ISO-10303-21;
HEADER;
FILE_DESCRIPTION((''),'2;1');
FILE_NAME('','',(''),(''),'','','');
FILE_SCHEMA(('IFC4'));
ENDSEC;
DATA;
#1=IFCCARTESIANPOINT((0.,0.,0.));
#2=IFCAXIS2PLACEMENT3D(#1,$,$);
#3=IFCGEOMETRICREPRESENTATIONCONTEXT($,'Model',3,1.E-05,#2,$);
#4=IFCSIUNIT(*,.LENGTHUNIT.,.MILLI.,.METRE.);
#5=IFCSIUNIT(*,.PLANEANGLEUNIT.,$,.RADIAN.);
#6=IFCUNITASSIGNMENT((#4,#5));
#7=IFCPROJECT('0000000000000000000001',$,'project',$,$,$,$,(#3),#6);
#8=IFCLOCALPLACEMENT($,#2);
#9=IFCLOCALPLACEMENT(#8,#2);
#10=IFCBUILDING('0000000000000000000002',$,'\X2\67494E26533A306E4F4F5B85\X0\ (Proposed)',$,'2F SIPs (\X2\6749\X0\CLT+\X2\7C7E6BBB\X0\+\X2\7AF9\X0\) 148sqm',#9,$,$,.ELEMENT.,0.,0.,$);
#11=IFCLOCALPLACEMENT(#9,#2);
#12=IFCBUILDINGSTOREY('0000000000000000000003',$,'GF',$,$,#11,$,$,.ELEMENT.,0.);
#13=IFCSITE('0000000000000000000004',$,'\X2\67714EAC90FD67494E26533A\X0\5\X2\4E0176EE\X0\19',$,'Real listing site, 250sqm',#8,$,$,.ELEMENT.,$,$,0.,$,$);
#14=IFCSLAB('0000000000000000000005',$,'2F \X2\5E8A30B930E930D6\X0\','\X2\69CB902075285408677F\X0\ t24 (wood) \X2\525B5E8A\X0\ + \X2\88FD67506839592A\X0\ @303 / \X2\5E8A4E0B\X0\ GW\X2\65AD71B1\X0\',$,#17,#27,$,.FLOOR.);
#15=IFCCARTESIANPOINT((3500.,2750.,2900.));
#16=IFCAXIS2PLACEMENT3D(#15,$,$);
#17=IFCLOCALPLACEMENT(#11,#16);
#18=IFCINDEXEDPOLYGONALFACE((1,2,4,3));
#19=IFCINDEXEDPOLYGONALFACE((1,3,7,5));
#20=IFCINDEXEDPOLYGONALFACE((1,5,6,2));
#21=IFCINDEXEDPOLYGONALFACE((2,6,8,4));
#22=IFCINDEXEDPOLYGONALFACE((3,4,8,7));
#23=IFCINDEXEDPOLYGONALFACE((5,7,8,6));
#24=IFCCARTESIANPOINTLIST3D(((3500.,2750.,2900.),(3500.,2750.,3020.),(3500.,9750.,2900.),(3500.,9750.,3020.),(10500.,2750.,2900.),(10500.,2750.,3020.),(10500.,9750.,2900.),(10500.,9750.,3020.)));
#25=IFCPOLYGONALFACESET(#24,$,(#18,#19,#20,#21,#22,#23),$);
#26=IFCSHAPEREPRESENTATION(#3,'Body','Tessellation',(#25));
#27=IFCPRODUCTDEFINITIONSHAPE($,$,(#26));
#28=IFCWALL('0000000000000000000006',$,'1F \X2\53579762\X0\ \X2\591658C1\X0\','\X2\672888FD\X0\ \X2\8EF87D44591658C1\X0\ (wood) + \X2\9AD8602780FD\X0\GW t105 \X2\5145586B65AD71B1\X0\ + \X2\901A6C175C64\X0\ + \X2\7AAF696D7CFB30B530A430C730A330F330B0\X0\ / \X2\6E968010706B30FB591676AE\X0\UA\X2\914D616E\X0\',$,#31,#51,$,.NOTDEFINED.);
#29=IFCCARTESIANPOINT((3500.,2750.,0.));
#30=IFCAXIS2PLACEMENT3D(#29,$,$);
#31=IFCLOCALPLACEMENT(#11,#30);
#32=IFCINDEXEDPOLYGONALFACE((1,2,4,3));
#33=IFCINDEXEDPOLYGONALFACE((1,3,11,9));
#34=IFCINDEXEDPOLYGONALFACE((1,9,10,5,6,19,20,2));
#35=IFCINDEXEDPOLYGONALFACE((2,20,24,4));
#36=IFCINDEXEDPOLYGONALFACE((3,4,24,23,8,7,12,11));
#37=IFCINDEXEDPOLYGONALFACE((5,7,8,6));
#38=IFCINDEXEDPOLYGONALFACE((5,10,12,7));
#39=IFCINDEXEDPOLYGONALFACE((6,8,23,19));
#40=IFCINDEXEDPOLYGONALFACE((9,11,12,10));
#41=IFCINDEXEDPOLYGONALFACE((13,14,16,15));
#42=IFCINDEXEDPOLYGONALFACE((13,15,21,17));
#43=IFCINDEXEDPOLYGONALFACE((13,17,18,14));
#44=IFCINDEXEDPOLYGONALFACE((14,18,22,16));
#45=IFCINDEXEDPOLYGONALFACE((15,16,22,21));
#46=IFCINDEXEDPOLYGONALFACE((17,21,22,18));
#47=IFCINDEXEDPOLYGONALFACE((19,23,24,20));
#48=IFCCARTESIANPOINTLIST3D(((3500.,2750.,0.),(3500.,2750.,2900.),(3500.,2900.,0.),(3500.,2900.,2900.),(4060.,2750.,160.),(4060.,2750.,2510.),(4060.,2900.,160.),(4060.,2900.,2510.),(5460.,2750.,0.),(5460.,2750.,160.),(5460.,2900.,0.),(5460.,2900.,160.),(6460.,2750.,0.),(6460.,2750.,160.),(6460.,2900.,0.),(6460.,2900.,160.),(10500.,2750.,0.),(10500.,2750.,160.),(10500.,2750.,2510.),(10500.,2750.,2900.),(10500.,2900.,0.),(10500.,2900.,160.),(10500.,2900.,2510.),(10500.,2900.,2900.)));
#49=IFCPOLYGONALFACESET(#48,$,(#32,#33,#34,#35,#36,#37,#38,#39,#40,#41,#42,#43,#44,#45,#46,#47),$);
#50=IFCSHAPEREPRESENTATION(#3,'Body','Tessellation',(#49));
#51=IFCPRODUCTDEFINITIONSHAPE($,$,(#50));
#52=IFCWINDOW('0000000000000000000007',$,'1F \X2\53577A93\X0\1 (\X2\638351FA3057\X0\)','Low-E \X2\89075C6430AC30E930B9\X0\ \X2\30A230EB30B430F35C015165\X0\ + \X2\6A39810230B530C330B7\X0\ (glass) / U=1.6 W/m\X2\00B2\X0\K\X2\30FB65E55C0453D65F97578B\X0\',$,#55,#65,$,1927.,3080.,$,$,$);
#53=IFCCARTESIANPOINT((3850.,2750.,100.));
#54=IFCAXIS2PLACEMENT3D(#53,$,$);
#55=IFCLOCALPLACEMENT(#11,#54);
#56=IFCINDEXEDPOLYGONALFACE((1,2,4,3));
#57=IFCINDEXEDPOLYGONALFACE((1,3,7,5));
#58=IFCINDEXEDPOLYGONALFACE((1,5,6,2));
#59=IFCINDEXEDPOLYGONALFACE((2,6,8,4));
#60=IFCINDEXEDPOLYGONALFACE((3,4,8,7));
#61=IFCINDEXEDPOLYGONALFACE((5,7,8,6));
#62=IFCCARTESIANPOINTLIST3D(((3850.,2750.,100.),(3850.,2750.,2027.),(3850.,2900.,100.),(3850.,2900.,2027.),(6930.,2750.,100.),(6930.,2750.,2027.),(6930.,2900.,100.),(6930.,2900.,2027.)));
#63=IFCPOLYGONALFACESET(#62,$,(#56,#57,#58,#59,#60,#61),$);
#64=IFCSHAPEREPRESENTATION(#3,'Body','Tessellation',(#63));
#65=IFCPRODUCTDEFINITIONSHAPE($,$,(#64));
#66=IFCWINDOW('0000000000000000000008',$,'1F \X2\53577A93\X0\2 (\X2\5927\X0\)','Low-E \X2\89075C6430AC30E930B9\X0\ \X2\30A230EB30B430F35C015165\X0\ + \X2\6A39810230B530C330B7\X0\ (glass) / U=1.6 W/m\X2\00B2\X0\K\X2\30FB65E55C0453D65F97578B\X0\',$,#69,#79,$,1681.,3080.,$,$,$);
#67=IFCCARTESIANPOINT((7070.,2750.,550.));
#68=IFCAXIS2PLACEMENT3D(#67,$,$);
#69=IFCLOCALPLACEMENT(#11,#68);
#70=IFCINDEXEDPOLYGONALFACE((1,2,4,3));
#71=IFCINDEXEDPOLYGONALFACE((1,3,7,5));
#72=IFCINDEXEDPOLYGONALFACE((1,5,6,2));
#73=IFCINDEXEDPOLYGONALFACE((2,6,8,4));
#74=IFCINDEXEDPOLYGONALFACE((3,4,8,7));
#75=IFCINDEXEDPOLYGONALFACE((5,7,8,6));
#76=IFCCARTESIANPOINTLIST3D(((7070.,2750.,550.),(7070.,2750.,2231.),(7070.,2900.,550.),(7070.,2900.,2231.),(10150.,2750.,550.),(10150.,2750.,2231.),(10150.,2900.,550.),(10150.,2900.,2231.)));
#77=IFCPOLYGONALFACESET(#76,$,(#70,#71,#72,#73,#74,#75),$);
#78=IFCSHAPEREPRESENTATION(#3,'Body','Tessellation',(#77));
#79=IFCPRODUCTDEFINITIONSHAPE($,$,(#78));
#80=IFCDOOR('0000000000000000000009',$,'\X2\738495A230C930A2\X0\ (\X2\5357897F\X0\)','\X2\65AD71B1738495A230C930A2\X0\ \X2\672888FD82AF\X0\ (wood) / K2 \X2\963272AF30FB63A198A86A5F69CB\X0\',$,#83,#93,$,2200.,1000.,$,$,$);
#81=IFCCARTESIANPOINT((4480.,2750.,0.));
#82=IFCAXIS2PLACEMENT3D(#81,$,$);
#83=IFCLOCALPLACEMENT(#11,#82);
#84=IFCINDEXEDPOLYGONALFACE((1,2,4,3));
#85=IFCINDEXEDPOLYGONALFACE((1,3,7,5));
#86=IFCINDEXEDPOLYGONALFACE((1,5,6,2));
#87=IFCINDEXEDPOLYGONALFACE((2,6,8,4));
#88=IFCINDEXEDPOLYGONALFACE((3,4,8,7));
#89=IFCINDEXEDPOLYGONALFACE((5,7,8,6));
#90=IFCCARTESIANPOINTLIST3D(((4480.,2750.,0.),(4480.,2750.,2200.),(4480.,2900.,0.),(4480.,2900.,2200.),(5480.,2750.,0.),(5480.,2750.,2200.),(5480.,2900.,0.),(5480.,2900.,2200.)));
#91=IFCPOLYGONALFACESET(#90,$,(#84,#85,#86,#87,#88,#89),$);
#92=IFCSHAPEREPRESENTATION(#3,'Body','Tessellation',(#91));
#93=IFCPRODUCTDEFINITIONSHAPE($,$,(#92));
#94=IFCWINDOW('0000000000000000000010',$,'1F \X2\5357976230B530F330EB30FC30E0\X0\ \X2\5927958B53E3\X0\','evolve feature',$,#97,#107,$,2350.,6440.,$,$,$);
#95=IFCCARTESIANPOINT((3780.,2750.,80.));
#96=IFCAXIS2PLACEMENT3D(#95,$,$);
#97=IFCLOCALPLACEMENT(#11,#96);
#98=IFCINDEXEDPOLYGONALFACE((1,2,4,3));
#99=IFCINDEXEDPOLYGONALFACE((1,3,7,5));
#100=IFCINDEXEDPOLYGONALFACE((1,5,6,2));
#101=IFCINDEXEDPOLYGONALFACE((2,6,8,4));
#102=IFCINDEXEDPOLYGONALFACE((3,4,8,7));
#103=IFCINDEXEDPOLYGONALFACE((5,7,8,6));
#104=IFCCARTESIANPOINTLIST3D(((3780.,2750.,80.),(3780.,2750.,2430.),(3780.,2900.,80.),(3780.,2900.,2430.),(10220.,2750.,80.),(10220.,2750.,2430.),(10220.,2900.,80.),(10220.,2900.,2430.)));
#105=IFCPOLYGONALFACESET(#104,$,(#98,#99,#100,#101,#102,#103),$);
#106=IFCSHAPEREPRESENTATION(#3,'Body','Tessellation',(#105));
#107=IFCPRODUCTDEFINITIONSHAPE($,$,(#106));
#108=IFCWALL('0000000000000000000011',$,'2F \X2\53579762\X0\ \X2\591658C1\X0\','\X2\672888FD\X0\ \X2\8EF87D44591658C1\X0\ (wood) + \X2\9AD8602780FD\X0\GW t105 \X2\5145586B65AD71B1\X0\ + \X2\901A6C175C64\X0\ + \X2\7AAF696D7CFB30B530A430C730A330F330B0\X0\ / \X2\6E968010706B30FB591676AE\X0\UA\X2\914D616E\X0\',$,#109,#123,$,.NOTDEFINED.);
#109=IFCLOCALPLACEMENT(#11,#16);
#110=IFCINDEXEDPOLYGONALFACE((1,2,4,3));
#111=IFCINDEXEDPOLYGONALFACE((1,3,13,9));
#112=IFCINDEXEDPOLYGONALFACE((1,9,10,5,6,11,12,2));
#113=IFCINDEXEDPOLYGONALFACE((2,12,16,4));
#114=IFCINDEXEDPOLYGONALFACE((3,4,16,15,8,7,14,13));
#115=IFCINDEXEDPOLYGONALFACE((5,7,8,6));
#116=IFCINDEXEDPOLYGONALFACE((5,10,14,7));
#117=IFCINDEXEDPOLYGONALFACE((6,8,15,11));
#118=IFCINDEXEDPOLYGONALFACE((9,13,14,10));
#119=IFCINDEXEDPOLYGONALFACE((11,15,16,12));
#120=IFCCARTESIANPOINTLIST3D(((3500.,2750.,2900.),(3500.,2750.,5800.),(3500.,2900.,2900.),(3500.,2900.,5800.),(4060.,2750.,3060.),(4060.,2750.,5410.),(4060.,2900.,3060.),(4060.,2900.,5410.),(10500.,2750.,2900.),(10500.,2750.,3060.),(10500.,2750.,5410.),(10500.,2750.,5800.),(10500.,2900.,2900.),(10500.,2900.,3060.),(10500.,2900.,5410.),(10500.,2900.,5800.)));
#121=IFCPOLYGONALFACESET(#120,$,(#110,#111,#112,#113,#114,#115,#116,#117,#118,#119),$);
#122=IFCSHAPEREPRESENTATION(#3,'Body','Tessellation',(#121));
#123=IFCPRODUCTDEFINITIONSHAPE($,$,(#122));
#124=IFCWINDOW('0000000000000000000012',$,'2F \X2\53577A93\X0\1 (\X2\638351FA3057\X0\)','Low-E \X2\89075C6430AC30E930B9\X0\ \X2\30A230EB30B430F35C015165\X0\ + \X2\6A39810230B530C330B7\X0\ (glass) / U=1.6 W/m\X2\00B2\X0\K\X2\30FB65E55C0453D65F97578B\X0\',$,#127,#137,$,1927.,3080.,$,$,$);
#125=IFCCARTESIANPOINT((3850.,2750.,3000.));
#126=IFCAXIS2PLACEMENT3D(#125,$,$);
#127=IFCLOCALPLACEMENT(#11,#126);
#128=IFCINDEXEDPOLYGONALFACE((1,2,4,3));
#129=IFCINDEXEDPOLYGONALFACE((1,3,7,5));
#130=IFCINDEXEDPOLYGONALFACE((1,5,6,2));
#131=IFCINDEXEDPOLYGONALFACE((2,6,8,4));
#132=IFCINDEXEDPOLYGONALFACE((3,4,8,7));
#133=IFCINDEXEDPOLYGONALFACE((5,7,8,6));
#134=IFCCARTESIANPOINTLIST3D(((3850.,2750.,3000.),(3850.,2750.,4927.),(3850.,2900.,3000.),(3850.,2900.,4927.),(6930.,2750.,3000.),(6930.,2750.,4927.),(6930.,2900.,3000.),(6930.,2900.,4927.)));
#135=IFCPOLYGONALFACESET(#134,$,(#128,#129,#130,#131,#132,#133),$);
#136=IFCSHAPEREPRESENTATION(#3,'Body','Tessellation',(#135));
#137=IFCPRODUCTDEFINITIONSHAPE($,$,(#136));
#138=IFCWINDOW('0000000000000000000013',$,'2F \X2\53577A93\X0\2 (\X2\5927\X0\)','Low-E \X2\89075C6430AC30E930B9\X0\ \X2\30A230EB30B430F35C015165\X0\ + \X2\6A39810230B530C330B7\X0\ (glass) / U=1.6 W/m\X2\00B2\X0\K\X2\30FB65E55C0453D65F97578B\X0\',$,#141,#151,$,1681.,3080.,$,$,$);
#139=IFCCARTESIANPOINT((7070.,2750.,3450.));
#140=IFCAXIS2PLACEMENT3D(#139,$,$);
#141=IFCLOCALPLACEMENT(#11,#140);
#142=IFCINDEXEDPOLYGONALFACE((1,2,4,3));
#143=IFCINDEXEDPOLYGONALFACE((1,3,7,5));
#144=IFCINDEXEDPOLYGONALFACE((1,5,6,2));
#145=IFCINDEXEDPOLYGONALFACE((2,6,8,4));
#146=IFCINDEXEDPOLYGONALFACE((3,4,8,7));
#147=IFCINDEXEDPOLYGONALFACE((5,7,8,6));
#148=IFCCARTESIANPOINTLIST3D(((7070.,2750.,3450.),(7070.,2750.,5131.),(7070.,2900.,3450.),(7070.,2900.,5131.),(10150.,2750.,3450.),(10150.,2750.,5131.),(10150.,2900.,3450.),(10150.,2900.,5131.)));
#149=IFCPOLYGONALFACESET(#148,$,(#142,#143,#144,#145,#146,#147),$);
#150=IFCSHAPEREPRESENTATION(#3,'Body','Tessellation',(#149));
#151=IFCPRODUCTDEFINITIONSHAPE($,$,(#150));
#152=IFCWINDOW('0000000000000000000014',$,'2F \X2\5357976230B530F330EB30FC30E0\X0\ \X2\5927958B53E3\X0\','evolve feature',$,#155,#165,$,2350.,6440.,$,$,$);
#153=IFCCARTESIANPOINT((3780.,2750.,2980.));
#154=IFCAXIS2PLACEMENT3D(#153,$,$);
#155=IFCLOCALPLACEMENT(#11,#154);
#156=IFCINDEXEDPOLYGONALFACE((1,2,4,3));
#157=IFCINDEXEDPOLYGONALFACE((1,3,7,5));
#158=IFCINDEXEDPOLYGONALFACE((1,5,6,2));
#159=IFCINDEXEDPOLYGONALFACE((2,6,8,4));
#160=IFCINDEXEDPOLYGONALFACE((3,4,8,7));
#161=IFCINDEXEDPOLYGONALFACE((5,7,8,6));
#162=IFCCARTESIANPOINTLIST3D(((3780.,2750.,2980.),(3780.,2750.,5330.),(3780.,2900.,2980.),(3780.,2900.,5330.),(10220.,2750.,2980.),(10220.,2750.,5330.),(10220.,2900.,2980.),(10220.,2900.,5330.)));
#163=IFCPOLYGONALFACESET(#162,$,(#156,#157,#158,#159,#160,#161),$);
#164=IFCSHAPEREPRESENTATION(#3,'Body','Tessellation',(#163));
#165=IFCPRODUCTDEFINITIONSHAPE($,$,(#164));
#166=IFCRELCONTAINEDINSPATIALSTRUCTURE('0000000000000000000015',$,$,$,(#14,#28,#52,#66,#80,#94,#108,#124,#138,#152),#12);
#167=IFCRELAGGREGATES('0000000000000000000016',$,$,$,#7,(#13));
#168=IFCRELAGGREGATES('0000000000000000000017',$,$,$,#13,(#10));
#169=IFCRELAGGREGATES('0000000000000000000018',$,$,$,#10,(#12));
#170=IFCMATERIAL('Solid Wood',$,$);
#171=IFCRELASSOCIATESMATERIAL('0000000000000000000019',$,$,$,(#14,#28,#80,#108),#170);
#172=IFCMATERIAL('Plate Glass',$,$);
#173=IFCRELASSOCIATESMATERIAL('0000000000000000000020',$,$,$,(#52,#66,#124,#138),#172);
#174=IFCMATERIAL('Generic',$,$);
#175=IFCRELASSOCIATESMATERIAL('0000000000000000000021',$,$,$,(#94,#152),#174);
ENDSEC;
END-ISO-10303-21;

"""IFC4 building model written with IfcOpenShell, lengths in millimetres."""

from ifc_helpers import new_model, si_unit, frame, frame_2d, origin, place, context, project, spatial, rectangle, extrude, material, element, fill, save


model = new_model("IFC4")

# Units and contexts
model_context = context("Model", 3, precision=1e-05, world=origin())
ifc_project = project(units=[si_unit("LENGTHUNIT", "METRE", prefix="MILLI"), si_unit("PLANEANGLEUNIT", "RADIAN")], contexts=[model_context])

# Site, building, storey
site_placement = place(None, origin())
site = spatial("IfcSite", under=ifc_project, at=site_placement, Name="東京都杉並区5丁目19", ObjectType="Real listing site, 250sqm", CompositionType="ELEMENT", RefElevation=0.0)
building_placement = place(site_placement, origin())
building = spatial("IfcBuilding", under=site, at=building_placement, Name="杉並区の住宅 (Proposed)", ObjectType="2F SIPs (杉CLT+籾殻+竹) 148sqm", CompositionType="ELEMENT", ElevationOfRefHeight=0.0, ElevationOfTerrain=0.0)
storey_placement = place(building_placement, origin())
storey = spatial("IfcBuildingStorey", under=building, at=storey_placement, Name="GF", CompositionType="ELEMENT", Elevation=0.0)

# Slab
ifc_material_1 = material(Name="Solid Wood")
slab_1_placement = place(storey_placement, frame((3500.0, 2750.0, 2900.0)))
element("IfcSlab", 1, at=slab_1_placement, inside=storey, material=ifc_material_1, Name="2F 床スラブ", Description="構造用合板 t24 (wood) 剛床 + 製材根太 @303 / 床下 GW断熱", PredefinedType="FLOOR", context=model_context, shape_type="SweptSolid", body=[
    extrude(rectangle(XDim=7000.0, YDim=7000.0, at=frame_2d((3500.0, 3500.0))), frame((3500.0, 2750.0, 2900.0)), (0.0, 0.0, 1.0), 120.0),
])
ifc_material_2 = material(Name="Generic")

# Wall, openings, windows, door
wall_1_placement = place(storey_placement, frame((3500.0, 2750.0, 0.0)))
wall_1 = element("IfcWall", 2, at=wall_1_placement, inside=storey, material=ifc_material_1, Name="1F 南面 外壁", Description="木製 軸組外壁 (wood) + 高性能GW t105 充填断熱 + 通気層 + 窯業系サイディング / 準耐火・外皮UA配慮", PredefinedType="NOTDEFINED", context=model_context, shape_type="SweptSolid", body=[
    extrude(rectangle(XDim=7000.0, YDim=150.0, at=frame_2d((3500.0, 75.0))), frame((3500.0, 2750.0, 0.0)), (0.0, 0.0, 1.0), 2900.0),
])
opening_1_placement = place(storey_placement, frame((3850.0, 2750.0, 100.0)))
opening_1 = element("IfcOpeningElement", 3, at=opening_1_placement, cuts=wall_1, PredefinedType="NOTDEFINED", context=model_context, shape_type="SweptSolid", body=[
    extrude(rectangle(XDim=3080.0, YDim=150.0, at=frame_2d((1540.0, 75.0))), frame((3850.0, 2750.0, 100.0)), (0.0, 0.0, 1.0), 1927.0),
])
opening_2_placement = place(storey_placement, frame((7070.0, 2750.0, 550.0)))
opening_2 = element("IfcOpeningElement", 4, at=opening_2_placement, cuts=wall_1, PredefinedType="NOTDEFINED", context=model_context, shape_type="SweptSolid", body=[
    extrude(rectangle(XDim=3080.0, YDim=150.0, at=frame_2d((1540.0, 75.0))), frame((7070.0, 2750.0, 550.0)), (0.0, 0.0, 1.0), 1681.0),
])
opening_3_placement = place(storey_placement, frame((4480.0, 2750.0, 0.0)))
opening_3 = element("IfcOpeningElement", 5, at=opening_3_placement, cuts=wall_1, PredefinedType="NOTDEFINED", context=model_context, shape_type="SweptSolid", body=[
    extrude(rectangle(XDim=1000.0, YDim=150.0, at=frame_2d((500.0, 75.0))), frame((4480.0, 2750.0, 0.0)), (0.0, 0.0, 1.0), 2200.0),
])
opening_4_placement = place(storey_placement, frame((3780.0, 2750.0, 80.0)))
opening_4 = element("IfcOpeningElement", 6, at=opening_4_placement, cuts=wall_1, PredefinedType="NOTDEFINED", context=model_context, shape_type="SweptSolid", body=[
    extrude(rectangle(XDim=6440.0, YDim=150.0, at=frame_2d((3220.0, 75.0))), frame((3780.0, 2750.0, 80.0)), (0.0, 0.0, 1.0), 2350.0),
])
ifc_material_3 = material(Name="Plate Glass")
window_1_placement = place(storey_placement, frame((3850.0, 2750.0, 100.0)))
window_1 = element("IfcWindow", 7, at=window_1_placement, inside=storey, material=ifc_material_3, Name="1F 南窓1 (掃出し)", Description="Low-E 複層ガラス アルゴン封入 + 樹脂サッシ (glass) / U=1.6 W/m²K・日射取得型", OverallHeight=1927.0, OverallWidth=3080.0, context=model_context, shape_type="SweptSolid", body=[
    extrude(rectangle(XDim=3080.0, YDim=150.0, at=frame_2d((1540.0, 75.0))), frame((3850.0, 2750.0, 100.0)), (0.0, 0.0, 1.0), 1927.0),
])
fill(opening_1, window_1)
window_2_placement = place(storey_placement, frame((7070.0, 2750.0, 550.0)))
window_2 = element("IfcWindow", 8, at=window_2_placement, inside=storey, material=ifc_material_3, Name="1F 南窓2 (大)", Description="Low-E 複層ガラス アルゴン封入 + 樹脂サッシ (glass) / U=1.6 W/m²K・日射取得型", OverallHeight=1681.0, OverallWidth=3080.0, context=model_context, shape_type="SweptSolid", body=[
    extrude(rectangle(XDim=3080.0, YDim=150.0, at=frame_2d((1540.0, 75.0))), frame((7070.0, 2750.0, 550.0)), (0.0, 0.0, 1.0), 1681.0),
])
fill(opening_2, window_2)
door_placement = place(storey_placement, frame((4480.0, 2750.0, 0.0)))
door = element("IfcDoor", 9, at=door_placement, inside=storey, material=ifc_material_1, Name="玄関ドア (南西)", Description="断熱玄関ドア 木製芯 (wood) / K2 防犯・採風機構", OverallHeight=2200.0, OverallWidth=1000.0, context=model_context, shape_type="SweptSolid", body=[
    extrude(rectangle(XDim=1000.0, YDim=150.0, at=frame_2d((500.0, 75.0))), frame((4480.0, 2750.0, 0.0)), (0.0, 0.0, 1.0), 2200.0),
])
fill(opening_3, door)
window_3_placement = place(storey_placement, frame((3780.0, 2750.0, 80.0)))
window_3 = element("IfcWindow", 10, at=window_3_placement, inside=storey, material=ifc_material_2, Name="1F 南面サンルーム 大開口", Description="evolve feature", OverallHeight=2350.0, OverallWidth=6440.0, context=model_context, shape_type="SweptSolid", body=[
    extrude(rectangle(XDim=6440.0, YDim=150.0, at=frame_2d((3220.0, 75.0))), frame((3780.0, 2750.0, 80.0)), (0.0, 0.0, 1.0), 2350.0),
])
fill(opening_4, window_3)

# Wall, openings, windows
wall_2_placement = place(storey_placement, frame((3500.0, 2750.0, 2900.0)))
wall_2 = element("IfcWall", 11, at=wall_2_placement, inside=storey, material=ifc_material_1, Name="2F 南面 外壁", Description="木製 軸組外壁 (wood) + 高性能GW t105 充填断熱 + 通気層 + 窯業系サイディング / 準耐火・外皮UA配慮", PredefinedType="NOTDEFINED", context=model_context, shape_type="SweptSolid", body=[
    extrude(rectangle(XDim=7000.0, YDim=150.0, at=frame_2d((3500.0, 75.0))), frame((3500.0, 2750.0, 2900.0)), (0.0, 0.0, 1.0), 2900.0),
])
opening_5_placement = place(storey_placement, frame((3850.0, 2750.0, 3000.0)))
opening_5 = element("IfcOpeningElement", 12, at=opening_5_placement, cuts=wall_2, PredefinedType="NOTDEFINED", context=model_context, shape_type="SweptSolid", body=[
    extrude(rectangle(XDim=3080.0, YDim=150.0, at=frame_2d((1540.0, 75.0))), frame((3850.0, 2750.0, 3000.0)), (0.0, 0.0, 1.0), 1927.0),
])
opening_6_placement = place(storey_placement, frame((7070.0, 2750.0, 3450.0)))
opening_6 = element("IfcOpeningElement", 13, at=opening_6_placement, cuts=wall_2, PredefinedType="NOTDEFINED", context=model_context, shape_type="SweptSolid", body=[
    extrude(rectangle(XDim=3080.0, YDim=150.0, at=frame_2d((1540.0, 75.0))), frame((7070.0, 2750.0, 3450.0)), (0.0, 0.0, 1.0), 1681.0),
])
opening_7_placement = place(storey_placement, frame((3780.0, 2750.0, 2980.0)))
opening_7 = element("IfcOpeningElement", 14, at=opening_7_placement, cuts=wall_2, PredefinedType="NOTDEFINED", context=model_context, shape_type="SweptSolid", body=[
    extrude(rectangle(XDim=6440.0, YDim=150.0, at=frame_2d((3220.0, 75.0))), frame((3780.0, 2750.0, 2980.0)), (0.0, 0.0, 1.0), 2350.0),
])
window_4_placement = place(storey_placement, frame((3850.0, 2750.0, 3000.0)))
window_4 = element("IfcWindow", 15, at=window_4_placement, inside=storey, material=ifc_material_3, Name="2F 南窓1 (掃出し)", Description="Low-E 複層ガラス アルゴン封入 + 樹脂サッシ (glass) / U=1.6 W/m²K・日射取得型", OverallHeight=1927.0, OverallWidth=3080.0, context=model_context, shape_type="SweptSolid", body=[
    extrude(rectangle(XDim=3080.0, YDim=150.0, at=frame_2d((1540.0, 75.0))), frame((3850.0, 2750.0, 3000.0)), (0.0, 0.0, 1.0), 1927.0),
])
fill(opening_5, window_4)
window_5_placement = place(storey_placement, frame((7070.0, 2750.0, 3450.0)))
window_5 = element("IfcWindow", 16, at=window_5_placement, inside=storey, material=ifc_material_3, Name="2F 南窓2 (大)", Description="Low-E 複層ガラス アルゴン封入 + 樹脂サッシ (glass) / U=1.6 W/m²K・日射取得型", OverallHeight=1681.0, OverallWidth=3080.0, context=model_context, shape_type="SweptSolid", body=[
    extrude(rectangle(XDim=3080.0, YDim=150.0, at=frame_2d((1540.0, 75.0))), frame((7070.0, 2750.0, 3450.0)), (0.0, 0.0, 1.0), 1681.0),
])
fill(opening_6, window_5)
window_6_placement = place(storey_placement, frame((3780.0, 2750.0, 2980.0)))
window_6 = element("IfcWindow", 17, at=window_6_placement, inside=storey, material=ifc_material_2, Name="2F 南面サンルーム 大開口", Description="evolve feature", OverallHeight=2350.0, OverallWidth=6440.0, context=model_context, shape_type="SweptSolid", body=[
    extrude(rectangle(XDim=6440.0, YDim=150.0, at=frame_2d((3220.0, 75.0))), frame((3780.0, 2750.0, 2980.0)), (0.0, 0.0, 1.0), 2350.0),
])
fill(opening_7, window_6)

save(model, "model.ifc")
